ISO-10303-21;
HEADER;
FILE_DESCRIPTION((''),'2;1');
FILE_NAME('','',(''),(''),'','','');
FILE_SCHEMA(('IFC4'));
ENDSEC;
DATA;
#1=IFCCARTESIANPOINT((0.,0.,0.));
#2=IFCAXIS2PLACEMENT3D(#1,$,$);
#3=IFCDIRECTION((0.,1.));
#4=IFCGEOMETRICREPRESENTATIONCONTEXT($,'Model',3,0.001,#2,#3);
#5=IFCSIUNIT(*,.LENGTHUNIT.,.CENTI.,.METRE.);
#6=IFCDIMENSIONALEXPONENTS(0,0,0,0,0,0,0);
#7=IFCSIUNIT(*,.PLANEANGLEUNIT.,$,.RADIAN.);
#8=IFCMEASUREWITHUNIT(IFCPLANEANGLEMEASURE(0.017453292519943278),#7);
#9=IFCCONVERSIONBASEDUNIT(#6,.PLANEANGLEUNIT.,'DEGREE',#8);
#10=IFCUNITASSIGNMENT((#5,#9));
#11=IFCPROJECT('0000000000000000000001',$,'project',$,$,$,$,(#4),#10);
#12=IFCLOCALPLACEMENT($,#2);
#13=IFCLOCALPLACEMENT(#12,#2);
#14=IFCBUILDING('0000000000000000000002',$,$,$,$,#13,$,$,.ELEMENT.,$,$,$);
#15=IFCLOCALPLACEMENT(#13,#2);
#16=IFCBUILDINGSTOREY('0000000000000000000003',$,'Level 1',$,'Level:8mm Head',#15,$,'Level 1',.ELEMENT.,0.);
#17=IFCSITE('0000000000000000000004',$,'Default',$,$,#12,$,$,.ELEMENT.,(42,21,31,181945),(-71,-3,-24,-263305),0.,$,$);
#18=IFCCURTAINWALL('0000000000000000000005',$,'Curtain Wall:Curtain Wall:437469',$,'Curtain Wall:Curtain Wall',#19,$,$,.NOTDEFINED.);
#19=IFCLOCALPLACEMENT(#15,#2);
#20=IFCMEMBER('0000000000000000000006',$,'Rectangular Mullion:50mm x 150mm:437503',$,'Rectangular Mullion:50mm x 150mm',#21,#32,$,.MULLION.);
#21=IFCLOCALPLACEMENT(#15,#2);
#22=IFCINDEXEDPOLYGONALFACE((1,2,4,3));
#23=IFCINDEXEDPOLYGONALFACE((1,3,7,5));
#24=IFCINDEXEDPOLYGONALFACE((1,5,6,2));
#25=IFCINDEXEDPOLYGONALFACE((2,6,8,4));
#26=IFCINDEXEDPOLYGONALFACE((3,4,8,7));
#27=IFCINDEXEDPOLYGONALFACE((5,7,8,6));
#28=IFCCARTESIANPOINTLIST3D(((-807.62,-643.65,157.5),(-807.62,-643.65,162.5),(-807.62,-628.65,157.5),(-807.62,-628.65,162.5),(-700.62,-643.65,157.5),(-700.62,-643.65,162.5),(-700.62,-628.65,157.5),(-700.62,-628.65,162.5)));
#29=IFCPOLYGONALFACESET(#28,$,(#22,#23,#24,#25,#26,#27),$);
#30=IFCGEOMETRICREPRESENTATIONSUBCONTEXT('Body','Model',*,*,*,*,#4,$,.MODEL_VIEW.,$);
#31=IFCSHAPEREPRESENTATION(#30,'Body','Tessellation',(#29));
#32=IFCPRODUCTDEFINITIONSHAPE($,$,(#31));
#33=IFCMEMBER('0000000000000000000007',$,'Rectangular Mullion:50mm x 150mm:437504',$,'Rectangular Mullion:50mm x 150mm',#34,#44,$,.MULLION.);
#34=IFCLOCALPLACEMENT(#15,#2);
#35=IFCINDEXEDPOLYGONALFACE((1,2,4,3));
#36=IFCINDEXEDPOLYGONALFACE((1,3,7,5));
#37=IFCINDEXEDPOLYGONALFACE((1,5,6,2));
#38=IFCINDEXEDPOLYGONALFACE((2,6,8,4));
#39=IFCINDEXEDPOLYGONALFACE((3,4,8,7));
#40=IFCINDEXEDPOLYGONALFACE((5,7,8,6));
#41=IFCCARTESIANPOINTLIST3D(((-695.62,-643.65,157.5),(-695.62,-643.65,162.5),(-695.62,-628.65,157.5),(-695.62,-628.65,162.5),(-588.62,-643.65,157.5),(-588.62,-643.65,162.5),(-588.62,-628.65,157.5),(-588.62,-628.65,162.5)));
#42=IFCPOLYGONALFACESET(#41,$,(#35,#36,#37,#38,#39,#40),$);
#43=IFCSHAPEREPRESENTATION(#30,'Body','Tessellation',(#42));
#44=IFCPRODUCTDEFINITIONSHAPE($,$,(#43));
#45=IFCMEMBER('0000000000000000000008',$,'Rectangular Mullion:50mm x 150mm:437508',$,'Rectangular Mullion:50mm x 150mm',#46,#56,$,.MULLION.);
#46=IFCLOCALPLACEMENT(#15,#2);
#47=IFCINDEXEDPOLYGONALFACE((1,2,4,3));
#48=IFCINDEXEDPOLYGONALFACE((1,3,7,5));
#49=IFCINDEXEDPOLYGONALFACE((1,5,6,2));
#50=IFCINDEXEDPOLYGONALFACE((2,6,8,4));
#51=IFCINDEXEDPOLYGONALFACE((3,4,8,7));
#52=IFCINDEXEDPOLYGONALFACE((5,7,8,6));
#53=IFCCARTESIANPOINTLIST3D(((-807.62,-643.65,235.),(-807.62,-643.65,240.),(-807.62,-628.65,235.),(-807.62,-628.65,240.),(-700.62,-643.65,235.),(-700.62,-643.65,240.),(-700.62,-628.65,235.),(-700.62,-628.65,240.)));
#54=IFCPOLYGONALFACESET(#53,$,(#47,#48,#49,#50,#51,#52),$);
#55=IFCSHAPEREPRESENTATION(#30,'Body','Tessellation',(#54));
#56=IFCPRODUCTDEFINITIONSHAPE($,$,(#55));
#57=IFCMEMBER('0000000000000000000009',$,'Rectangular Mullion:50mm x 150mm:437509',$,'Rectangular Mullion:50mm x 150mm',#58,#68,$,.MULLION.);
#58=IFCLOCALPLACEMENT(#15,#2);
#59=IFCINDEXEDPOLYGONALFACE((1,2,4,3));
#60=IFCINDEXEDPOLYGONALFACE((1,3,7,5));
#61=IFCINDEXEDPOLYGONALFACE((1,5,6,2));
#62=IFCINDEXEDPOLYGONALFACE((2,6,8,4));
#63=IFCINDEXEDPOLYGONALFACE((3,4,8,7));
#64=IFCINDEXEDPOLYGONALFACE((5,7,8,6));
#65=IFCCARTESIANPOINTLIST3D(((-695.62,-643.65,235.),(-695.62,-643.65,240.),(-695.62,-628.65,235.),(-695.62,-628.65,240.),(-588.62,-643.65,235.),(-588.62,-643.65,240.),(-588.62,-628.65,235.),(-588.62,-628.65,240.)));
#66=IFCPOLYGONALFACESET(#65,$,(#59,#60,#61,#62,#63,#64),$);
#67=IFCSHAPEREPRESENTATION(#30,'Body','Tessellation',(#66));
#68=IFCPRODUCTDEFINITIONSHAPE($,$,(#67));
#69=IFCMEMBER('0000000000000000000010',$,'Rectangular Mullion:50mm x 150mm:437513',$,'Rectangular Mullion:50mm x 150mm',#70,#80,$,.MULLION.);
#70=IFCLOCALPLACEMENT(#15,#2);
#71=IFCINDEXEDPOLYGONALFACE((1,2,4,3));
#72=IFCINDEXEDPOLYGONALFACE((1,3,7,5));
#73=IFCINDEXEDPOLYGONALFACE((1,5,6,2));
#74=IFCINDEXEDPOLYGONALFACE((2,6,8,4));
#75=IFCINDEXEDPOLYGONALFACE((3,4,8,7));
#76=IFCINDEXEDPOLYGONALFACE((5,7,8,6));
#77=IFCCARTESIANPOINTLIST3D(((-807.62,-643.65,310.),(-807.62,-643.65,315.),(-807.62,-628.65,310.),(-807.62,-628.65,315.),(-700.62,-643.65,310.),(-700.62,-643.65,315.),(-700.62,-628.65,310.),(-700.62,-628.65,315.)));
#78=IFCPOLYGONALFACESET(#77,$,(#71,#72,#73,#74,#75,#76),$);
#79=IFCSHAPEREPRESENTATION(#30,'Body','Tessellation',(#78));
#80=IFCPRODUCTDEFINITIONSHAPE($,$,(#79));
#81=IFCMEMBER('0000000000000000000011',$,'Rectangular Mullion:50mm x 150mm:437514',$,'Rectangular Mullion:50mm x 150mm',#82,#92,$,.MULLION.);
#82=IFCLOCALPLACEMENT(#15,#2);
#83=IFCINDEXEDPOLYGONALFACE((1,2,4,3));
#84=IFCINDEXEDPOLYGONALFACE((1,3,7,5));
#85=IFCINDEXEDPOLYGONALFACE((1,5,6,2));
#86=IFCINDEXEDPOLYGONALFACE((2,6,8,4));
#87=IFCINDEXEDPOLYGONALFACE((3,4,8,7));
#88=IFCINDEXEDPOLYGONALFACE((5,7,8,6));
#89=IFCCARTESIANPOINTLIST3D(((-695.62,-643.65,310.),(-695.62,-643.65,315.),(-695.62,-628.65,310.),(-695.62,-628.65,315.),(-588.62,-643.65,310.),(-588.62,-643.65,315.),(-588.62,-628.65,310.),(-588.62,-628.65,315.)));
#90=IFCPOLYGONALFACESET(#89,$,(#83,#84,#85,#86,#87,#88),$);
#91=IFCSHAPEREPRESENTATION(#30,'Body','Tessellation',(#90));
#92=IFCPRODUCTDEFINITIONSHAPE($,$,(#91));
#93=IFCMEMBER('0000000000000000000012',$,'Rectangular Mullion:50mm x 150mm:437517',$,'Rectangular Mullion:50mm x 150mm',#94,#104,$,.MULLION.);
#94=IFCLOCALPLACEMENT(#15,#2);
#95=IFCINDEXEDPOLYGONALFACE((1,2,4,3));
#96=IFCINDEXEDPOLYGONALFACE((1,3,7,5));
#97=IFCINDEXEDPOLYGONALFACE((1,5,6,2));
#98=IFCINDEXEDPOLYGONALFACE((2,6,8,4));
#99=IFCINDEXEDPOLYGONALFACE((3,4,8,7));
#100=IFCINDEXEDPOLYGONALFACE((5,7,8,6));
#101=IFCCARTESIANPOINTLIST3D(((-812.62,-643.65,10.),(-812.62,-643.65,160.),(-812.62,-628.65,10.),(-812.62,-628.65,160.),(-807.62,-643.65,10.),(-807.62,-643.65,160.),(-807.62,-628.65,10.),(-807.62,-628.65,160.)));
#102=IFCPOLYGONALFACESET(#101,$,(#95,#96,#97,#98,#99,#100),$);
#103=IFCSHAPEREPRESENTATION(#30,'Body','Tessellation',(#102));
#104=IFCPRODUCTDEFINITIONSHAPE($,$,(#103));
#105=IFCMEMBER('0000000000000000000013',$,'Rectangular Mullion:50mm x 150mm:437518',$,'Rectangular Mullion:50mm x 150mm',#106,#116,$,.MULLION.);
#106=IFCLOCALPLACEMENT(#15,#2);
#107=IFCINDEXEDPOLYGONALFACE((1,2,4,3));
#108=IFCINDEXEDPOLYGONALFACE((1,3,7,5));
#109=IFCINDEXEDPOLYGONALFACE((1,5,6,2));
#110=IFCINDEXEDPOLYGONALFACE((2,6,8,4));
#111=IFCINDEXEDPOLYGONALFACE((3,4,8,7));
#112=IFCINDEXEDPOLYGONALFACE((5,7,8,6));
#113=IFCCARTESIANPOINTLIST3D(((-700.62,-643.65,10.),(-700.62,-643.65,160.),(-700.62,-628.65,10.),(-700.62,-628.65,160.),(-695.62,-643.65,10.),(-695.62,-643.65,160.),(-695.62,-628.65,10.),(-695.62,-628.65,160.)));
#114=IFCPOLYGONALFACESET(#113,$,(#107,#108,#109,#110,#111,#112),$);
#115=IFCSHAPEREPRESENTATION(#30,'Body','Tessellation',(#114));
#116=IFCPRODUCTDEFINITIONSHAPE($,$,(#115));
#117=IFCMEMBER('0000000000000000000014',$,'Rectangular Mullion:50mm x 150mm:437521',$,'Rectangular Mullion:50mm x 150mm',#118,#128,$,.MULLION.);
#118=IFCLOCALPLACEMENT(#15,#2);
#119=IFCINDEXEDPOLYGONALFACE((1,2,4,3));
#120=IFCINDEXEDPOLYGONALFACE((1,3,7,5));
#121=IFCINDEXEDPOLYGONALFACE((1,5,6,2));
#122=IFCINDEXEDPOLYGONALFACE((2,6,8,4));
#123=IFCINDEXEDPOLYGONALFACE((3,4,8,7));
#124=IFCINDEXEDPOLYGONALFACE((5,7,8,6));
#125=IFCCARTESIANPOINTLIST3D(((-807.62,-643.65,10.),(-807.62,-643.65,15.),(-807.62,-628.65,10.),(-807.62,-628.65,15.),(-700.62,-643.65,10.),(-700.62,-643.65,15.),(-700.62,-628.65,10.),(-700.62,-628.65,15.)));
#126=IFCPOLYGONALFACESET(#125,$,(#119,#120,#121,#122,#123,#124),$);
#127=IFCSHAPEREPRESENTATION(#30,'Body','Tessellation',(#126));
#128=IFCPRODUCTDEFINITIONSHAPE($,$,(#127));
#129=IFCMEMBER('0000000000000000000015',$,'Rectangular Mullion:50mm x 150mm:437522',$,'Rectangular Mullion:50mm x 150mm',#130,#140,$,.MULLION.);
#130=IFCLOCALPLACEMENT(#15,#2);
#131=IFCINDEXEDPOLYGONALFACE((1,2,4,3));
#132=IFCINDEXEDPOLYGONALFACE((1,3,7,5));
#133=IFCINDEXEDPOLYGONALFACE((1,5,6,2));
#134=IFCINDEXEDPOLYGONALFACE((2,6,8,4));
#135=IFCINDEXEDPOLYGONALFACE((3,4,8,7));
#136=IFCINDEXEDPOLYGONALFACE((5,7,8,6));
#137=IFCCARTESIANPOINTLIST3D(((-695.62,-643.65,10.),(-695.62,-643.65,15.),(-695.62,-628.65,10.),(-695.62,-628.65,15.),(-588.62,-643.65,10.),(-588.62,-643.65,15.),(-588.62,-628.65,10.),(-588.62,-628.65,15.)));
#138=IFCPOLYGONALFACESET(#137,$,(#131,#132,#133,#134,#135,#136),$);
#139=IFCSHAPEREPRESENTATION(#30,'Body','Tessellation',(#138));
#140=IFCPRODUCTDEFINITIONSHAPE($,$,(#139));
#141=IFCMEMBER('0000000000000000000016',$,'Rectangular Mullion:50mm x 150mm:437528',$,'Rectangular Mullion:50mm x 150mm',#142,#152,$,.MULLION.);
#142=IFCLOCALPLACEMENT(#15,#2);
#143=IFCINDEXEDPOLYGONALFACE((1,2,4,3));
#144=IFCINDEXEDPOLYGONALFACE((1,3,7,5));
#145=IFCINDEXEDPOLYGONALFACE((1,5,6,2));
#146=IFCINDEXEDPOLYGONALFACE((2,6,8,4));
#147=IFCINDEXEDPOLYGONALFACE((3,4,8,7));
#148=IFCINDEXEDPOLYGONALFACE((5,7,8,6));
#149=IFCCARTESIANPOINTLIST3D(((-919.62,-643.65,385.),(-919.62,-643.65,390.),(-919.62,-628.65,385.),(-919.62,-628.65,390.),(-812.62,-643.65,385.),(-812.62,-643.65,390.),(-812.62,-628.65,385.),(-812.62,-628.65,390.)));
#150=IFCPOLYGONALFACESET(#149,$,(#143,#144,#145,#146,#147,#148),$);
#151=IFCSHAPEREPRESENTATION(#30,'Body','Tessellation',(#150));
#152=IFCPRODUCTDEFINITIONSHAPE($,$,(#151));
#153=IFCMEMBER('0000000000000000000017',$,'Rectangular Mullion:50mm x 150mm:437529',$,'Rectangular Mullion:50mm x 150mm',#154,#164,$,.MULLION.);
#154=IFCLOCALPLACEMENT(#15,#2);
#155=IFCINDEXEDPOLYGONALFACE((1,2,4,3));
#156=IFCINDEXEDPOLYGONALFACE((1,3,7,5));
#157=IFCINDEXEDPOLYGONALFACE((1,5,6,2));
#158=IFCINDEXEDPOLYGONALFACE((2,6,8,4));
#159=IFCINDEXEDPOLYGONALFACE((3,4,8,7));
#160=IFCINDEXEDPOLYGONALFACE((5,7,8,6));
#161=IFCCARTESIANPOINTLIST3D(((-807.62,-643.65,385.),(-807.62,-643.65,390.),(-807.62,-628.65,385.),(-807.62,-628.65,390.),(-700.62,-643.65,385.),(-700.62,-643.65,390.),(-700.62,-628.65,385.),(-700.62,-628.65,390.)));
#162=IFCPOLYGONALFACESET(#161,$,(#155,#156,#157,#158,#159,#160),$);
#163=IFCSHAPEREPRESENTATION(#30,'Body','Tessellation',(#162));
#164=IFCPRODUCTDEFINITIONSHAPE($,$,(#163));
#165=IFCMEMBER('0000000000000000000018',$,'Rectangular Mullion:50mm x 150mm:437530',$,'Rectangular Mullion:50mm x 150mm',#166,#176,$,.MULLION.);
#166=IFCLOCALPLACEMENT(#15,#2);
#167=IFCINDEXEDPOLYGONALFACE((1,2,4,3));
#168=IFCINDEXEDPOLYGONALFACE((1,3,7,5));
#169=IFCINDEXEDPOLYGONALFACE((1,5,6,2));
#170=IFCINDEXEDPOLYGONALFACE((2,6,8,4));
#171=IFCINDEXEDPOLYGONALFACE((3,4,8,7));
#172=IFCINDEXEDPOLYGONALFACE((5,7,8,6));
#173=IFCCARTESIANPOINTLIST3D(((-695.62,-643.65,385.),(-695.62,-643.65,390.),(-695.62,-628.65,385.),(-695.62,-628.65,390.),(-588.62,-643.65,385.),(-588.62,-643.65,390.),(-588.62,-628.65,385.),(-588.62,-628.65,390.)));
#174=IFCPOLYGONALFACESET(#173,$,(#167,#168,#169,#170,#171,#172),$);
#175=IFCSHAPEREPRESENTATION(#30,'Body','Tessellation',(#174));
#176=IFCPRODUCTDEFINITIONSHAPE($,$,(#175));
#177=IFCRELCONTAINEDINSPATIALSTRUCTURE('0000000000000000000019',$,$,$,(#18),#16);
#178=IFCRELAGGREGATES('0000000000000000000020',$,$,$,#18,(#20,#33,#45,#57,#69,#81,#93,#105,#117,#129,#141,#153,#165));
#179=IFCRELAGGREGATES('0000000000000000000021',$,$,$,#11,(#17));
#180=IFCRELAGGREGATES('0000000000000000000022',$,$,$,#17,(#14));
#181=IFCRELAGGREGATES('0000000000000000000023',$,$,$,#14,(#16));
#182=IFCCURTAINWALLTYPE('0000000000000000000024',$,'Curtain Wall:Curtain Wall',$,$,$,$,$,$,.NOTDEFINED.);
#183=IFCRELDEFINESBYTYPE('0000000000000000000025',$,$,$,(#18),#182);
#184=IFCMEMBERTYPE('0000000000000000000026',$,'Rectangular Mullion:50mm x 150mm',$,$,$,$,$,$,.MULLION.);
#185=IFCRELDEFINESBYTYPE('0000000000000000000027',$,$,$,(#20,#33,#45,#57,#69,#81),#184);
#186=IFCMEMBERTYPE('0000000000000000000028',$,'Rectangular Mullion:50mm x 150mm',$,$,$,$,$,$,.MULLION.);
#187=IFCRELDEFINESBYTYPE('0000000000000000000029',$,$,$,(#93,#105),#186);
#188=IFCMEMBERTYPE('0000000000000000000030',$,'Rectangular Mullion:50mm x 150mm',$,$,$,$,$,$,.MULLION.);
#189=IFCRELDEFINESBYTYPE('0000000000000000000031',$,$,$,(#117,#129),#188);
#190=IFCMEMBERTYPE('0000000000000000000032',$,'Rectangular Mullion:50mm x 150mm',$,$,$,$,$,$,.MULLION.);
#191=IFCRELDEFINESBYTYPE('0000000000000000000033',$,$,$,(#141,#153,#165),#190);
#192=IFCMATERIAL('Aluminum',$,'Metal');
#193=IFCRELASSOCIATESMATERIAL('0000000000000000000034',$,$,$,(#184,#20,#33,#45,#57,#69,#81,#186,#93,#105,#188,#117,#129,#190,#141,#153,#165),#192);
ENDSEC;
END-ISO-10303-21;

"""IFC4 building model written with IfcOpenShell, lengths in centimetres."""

from ifc_helpers import new_model, entity, si_unit, converted_unit, direction, frame, origin, place, context, subcontext, project, spatial, indexed_curve, outline, extrude, source, transform, mapped, material, type_object, type_shapes, element, aggregate, save


model = new_model("IFC4")

# Units and contexts
model_context = context("Model", 3, precision=0.001, world=origin(), true_north=direction((0.0, 1.0)))
body_context = subcontext(model_context, "Body", "Model", "MODEL_VIEW")
ifc_project = project(units=[si_unit("LENGTHUNIT", "METRE", prefix="CENTI"), converted_unit("PLANEANGLEUNIT", "DEGREE", entity("IfcPlaneAngleMeasure", 0.017453292519943278), si_unit("PLANEANGLEUNIT", "RADIAN"), dimensions=[0, 0, 0, 0, 0, 0, 0])], contexts=[model_context])

# Site, building, storey
site_placement = place(None, origin())
site = spatial("IfcSite", under=ifc_project, at=site_placement, Name="Default", CompositionType="ELEMENT", RefLatitude=(42, 21, 31, 181945), RefLongitude=(-71, -3, -24, -263305), RefElevation=0.0)
building_placement = place(site_placement, origin())
building = spatial("IfcBuilding", under=site, at=building_placement, CompositionType="ELEMENT")
storey_placement = place(building_placement, origin())
storey = spatial("IfcBuildingStorey", under=building, at=storey_placement, Name="Level 1", ObjectType="Level:8mm Head", LongName="Level 1", CompositionType="ELEMENT", Elevation=0.0)

# Curtain wall, members
curtain_wall_type = type_object("IfcCurtainWallType", Name="Curtain Wall:Curtain Wall", PredefinedType="NOTDEFINED")
curtain_wall_placement = place(storey_placement, origin())
curtain_wall = element("IfcCurtainWall", 1, at=curtain_wall_placement, inside=storey, type_object=curtain_wall_type, Name="Curtain Wall:Curtain Wall:437469", ObjectType="Curtain Wall:Curtain Wall", PredefinedType="NOTDEFINED")
ifc_material_1 = material(Name="Aluminum", Category="Metal")
member_type_1 = type_object("IfcMemberType", Name="Rectangular Mullion:50mm x 150mm", PredefinedType="MULLION", material=ifc_material_1)
shared_shape_1 = source(origin(), body_context, "Body", "SweptSolid", [
    extrude(outline(indexed_curve([(-2.5, -7.5), (2.5, -7.5), (2.5, 7.5), (-2.5, 7.5), (-2.5, -7.5)], self_intersect=False)), frame((0.0, 0.0, -107.0), z_axis=(0.0, 0.0, 1.0), x_axis=(-1.0, 0.0, 0.0)), (0.0, 0.0, 1.0), 107.0),
])
type_shapes(member_type_1, [shared_shape_1])
member_1_placement = place(curtain_wall_placement, frame((-700.62, -636.15, 160.0), z_axis=(1.0, 0.0, 0.0), x_axis=(0.0, 0.0, 1.0)))
member_1 = element("IfcMember", 2, at=member_1_placement, type_object=member_type_1, material=ifc_material_1, Name="Rectangular Mullion:50mm x 150mm:437503", ObjectType="Rectangular Mullion:50mm x 150mm", PredefinedType="MULLION", context=body_context, shape_type="MappedRepresentation", body=[
    mapped(shared_shape_1, transform((0.0, 0.0, 0.0), scale=1.0)),
])
member_2_placement = place(curtain_wall_placement, frame((-588.62, -636.15, 160.0), z_axis=(1.0, 0.0, 0.0), x_axis=(0.0, 0.0, 1.0)))
member_2 = element("IfcMember", 3, at=member_2_placement, type_object=member_type_1, material=ifc_material_1, Name="Rectangular Mullion:50mm x 150mm:437504", ObjectType="Rectangular Mullion:50mm x 150mm", PredefinedType="MULLION", context=body_context, shape_type="MappedRepresentation", body=[
    mapped(shared_shape_1, transform((0.0, 0.0, 0.0), scale=1.0)),
])
member_3_placement = place(curtain_wall_placement, frame((-700.62, -636.15, 237.5), z_axis=(1.0, 0.0, 0.0), x_axis=(0.0, 0.0, 1.0)))
member_3 = element("IfcMember", 4, at=member_3_placement, type_object=member_type_1, material=ifc_material_1, Name="Rectangular Mullion:50mm x 150mm:437508", ObjectType="Rectangular Mullion:50mm x 150mm", PredefinedType="MULLION", context=body_context, shape_type="MappedRepresentation", body=[
    mapped(shared_shape_1, transform((0.0, 0.0, 0.0), scale=1.0)),
])
member_4_placement = place(curtain_wall_placement, frame((-588.62, -636.15, 237.5), z_axis=(1.0, 0.0, 0.0), x_axis=(0.0, 0.0, 1.0)))
member_4 = element("IfcMember", 5, at=member_4_placement, type_object=member_type_1, material=ifc_material_1, Name="Rectangular Mullion:50mm x 150mm:437509", ObjectType="Rectangular Mullion:50mm x 150mm", PredefinedType="MULLION", context=body_context, shape_type="MappedRepresentation", body=[
    mapped(shared_shape_1, transform((0.0, 0.0, 0.0), scale=1.0)),
])
member_5_placement = place(curtain_wall_placement, frame((-700.62, -636.15, 312.5), z_axis=(1.0, 0.0, 0.0), x_axis=(0.0, 0.0, 1.0)))
member_5 = element("IfcMember", 6, at=member_5_placement, type_object=member_type_1, material=ifc_material_1, Name="Rectangular Mullion:50mm x 150mm:437513", ObjectType="Rectangular Mullion:50mm x 150mm", PredefinedType="MULLION", context=body_context, shape_type="MappedRepresentation", body=[
    mapped(shared_shape_1, transform((0.0, 0.0, 0.0), scale=1.0)),
])
member_6_placement = place(curtain_wall_placement, frame((-588.62, -636.15, 312.5), z_axis=(1.0, 0.0, 0.0), x_axis=(0.0, 0.0, 1.0)))
member_6 = element("IfcMember", 7, at=member_6_placement, type_object=member_type_1, material=ifc_material_1, Name="Rectangular Mullion:50mm x 150mm:437514", ObjectType="Rectangular Mullion:50mm x 150mm", PredefinedType="MULLION", context=body_context, shape_type="MappedRepresentation", body=[
    mapped(shared_shape_1, transform((0.0, 0.0, 0.0), scale=1.0)),
])
member_type_2 = type_object("IfcMemberType", Name="Rectangular Mullion:50mm x 150mm", PredefinedType="MULLION", material=ifc_material_1)
shared_shape_2 = source(origin(), body_context, "Body", "SweptSolid", [
    extrude(outline(indexed_curve([(-2.5, -7.5), (2.5, -7.5), (2.5, 7.5), (-2.5, 7.5), (-2.5, -7.5)], self_intersect=False)), frame((0.0, 0.0, -150.0), z_axis=(0.0, 0.0, 1.0), x_axis=(-1.0, 0.0, 0.0)), (0.0, 0.0, 1.0), 150.0),
])
type_shapes(member_type_2, [shared_shape_2])
member_7_placement = place(curtain_wall_placement, frame((-810.12, -636.15, 10.0), z_axis=(0.0, 0.0, -1.0), x_axis=(1.0, 0.0, 0.0)))
member_7 = element("IfcMember", 8, at=member_7_placement, type_object=member_type_2, material=ifc_material_1, Name="Rectangular Mullion:50mm x 150mm:437517", ObjectType="Rectangular Mullion:50mm x 150mm", PredefinedType="MULLION", context=body_context, shape_type="MappedRepresentation", body=[
    mapped(shared_shape_2, transform((0.0, 0.0, 0.0), scale=1.0)),
])
member_8_placement = place(curtain_wall_placement, frame((-698.12, -636.15, 10.0), z_axis=(0.0, 0.0, -1.0), x_axis=(1.0, 0.0, 0.0)))
member_8 = element("IfcMember", 9, at=member_8_placement, type_object=member_type_2, material=ifc_material_1, Name="Rectangular Mullion:50mm x 150mm:437518", ObjectType="Rectangular Mullion:50mm x 150mm", PredefinedType="MULLION", context=body_context, shape_type="MappedRepresentation", body=[
    mapped(shared_shape_2, transform((0.0, 0.0, 0.0), scale=1.0)),
])
member_type_3 = type_object("IfcMemberType", Name="Rectangular Mullion:50mm x 150mm", PredefinedType="MULLION", material=ifc_material_1)
shared_shape_3 = source(origin(), body_context, "Body", "SweptSolid", [
    extrude(outline(indexed_curve([(-2.5, -7.5), (2.5, -7.5), (2.5, 7.5), (-2.5, 7.5), (-2.5, -7.5)], self_intersect=False)), frame((-2.5, 0.0, -107.0), z_axis=(0.0, 0.0, 1.0), x_axis=(-1.0, 0.0, 0.0)), (0.0, 0.0, 1.0), 107.0),
])
type_shapes(member_type_3, [shared_shape_3])
member_9_placement = place(curtain_wall_placement, frame((-807.62, -636.15, 10.0), z_axis=(-1.0, 0.0, 0.0), x_axis=(0.0, 0.0, -1.0)))
member_9 = element("IfcMember", 10, at=member_9_placement, type_object=member_type_3, material=ifc_material_1, Name="Rectangular Mullion:50mm x 150mm:437521", ObjectType="Rectangular Mullion:50mm x 150mm", PredefinedType="MULLION", context=body_context, shape_type="MappedRepresentation", body=[
    mapped(shared_shape_3, transform((0.0, 0.0, 0.0), scale=1.0)),
])
member_10_placement = place(curtain_wall_placement, frame((-695.62, -636.15, 10.0), z_axis=(-1.0, 0.0, 0.0), x_axis=(0.0, 0.0, -1.0)))
member_10 = element("IfcMember", 11, at=member_10_placement, type_object=member_type_3, material=ifc_material_1, Name="Rectangular Mullion:50mm x 150mm:437522", ObjectType="Rectangular Mullion:50mm x 150mm", PredefinedType="MULLION", context=body_context, shape_type="MappedRepresentation", body=[
    mapped(shared_shape_3, transform((0.0, 0.0, 0.0), scale=1.0)),
])
member_type_4 = type_object("IfcMemberType", Name="Rectangular Mullion:50mm x 150mm", PredefinedType="MULLION", material=ifc_material_1)
shared_shape_4 = source(origin(), body_context, "Body", "SweptSolid", [
    extrude(outline(indexed_curve([(-2.5, -7.5), (2.5, -7.5), (2.5, 7.5), (-2.5, 7.5), (-2.5, -7.5)], self_intersect=False)), frame((-2.5, 0.0, -107.0), z_axis=(0.0, 0.0, 1.0), x_axis=(-1.0, 0.0, 0.0)), (0.0, 0.0, 1.0), 107.0),
])
type_shapes(member_type_4, [shared_shape_4])
member_11_placement = place(curtain_wall_placement, frame((-812.62, -636.15, 390.0), z_axis=(1.0, 0.0, 0.0), x_axis=(0.0, 0.0, 1.0)))
member_11 = element("IfcMember", 12, at=member_11_placement, type_object=member_type_4, material=ifc_material_1, Name="Rectangular Mullion:50mm x 150mm:437528", ObjectType="Rectangular Mullion:50mm x 150mm", PredefinedType="MULLION", context=body_context, shape_type="MappedRepresentation", body=[
    mapped(shared_shape_4, transform((0.0, 0.0, 0.0), scale=1.0)),
])
member_12_placement = place(curtain_wall_placement, frame((-700.62, -636.15, 390.0), z_axis=(1.0, 0.0, 0.0), x_axis=(0.0, 0.0, 1.0)))
member_12 = element("IfcMember", 13, at=member_12_placement, type_object=member_type_4, material=ifc_material_1, Name="Rectangular Mullion:50mm x 150mm:437529", ObjectType="Rectangular Mullion:50mm x 150mm", PredefinedType="MULLION", context=body_context, shape_type="MappedRepresentation", body=[
    mapped(shared_shape_4, transform((0.0, 0.0, 0.0), scale=1.0)),
])
member_13_placement = place(curtain_wall_placement, frame((-588.62, -636.15, 390.0), z_axis=(1.0, 0.0, 0.0), x_axis=(0.0, 0.0, 1.0)))
member_13 = element("IfcMember", 14, at=member_13_placement, type_object=member_type_4, material=ifc_material_1, Name="Rectangular Mullion:50mm x 150mm:437530", ObjectType="Rectangular Mullion:50mm x 150mm", PredefinedType="MULLION", context=body_context, shape_type="MappedRepresentation", body=[
    mapped(shared_shape_4, transform((0.0, 0.0, 0.0), scale=1.0)),
])
aggregate(curtain_wall, [member_1, member_2, member_3, member_4, member_5, member_6, member_7, member_8, member_9, member_10, member_11, member_12, member_13])

save(model, "model.ifc")
